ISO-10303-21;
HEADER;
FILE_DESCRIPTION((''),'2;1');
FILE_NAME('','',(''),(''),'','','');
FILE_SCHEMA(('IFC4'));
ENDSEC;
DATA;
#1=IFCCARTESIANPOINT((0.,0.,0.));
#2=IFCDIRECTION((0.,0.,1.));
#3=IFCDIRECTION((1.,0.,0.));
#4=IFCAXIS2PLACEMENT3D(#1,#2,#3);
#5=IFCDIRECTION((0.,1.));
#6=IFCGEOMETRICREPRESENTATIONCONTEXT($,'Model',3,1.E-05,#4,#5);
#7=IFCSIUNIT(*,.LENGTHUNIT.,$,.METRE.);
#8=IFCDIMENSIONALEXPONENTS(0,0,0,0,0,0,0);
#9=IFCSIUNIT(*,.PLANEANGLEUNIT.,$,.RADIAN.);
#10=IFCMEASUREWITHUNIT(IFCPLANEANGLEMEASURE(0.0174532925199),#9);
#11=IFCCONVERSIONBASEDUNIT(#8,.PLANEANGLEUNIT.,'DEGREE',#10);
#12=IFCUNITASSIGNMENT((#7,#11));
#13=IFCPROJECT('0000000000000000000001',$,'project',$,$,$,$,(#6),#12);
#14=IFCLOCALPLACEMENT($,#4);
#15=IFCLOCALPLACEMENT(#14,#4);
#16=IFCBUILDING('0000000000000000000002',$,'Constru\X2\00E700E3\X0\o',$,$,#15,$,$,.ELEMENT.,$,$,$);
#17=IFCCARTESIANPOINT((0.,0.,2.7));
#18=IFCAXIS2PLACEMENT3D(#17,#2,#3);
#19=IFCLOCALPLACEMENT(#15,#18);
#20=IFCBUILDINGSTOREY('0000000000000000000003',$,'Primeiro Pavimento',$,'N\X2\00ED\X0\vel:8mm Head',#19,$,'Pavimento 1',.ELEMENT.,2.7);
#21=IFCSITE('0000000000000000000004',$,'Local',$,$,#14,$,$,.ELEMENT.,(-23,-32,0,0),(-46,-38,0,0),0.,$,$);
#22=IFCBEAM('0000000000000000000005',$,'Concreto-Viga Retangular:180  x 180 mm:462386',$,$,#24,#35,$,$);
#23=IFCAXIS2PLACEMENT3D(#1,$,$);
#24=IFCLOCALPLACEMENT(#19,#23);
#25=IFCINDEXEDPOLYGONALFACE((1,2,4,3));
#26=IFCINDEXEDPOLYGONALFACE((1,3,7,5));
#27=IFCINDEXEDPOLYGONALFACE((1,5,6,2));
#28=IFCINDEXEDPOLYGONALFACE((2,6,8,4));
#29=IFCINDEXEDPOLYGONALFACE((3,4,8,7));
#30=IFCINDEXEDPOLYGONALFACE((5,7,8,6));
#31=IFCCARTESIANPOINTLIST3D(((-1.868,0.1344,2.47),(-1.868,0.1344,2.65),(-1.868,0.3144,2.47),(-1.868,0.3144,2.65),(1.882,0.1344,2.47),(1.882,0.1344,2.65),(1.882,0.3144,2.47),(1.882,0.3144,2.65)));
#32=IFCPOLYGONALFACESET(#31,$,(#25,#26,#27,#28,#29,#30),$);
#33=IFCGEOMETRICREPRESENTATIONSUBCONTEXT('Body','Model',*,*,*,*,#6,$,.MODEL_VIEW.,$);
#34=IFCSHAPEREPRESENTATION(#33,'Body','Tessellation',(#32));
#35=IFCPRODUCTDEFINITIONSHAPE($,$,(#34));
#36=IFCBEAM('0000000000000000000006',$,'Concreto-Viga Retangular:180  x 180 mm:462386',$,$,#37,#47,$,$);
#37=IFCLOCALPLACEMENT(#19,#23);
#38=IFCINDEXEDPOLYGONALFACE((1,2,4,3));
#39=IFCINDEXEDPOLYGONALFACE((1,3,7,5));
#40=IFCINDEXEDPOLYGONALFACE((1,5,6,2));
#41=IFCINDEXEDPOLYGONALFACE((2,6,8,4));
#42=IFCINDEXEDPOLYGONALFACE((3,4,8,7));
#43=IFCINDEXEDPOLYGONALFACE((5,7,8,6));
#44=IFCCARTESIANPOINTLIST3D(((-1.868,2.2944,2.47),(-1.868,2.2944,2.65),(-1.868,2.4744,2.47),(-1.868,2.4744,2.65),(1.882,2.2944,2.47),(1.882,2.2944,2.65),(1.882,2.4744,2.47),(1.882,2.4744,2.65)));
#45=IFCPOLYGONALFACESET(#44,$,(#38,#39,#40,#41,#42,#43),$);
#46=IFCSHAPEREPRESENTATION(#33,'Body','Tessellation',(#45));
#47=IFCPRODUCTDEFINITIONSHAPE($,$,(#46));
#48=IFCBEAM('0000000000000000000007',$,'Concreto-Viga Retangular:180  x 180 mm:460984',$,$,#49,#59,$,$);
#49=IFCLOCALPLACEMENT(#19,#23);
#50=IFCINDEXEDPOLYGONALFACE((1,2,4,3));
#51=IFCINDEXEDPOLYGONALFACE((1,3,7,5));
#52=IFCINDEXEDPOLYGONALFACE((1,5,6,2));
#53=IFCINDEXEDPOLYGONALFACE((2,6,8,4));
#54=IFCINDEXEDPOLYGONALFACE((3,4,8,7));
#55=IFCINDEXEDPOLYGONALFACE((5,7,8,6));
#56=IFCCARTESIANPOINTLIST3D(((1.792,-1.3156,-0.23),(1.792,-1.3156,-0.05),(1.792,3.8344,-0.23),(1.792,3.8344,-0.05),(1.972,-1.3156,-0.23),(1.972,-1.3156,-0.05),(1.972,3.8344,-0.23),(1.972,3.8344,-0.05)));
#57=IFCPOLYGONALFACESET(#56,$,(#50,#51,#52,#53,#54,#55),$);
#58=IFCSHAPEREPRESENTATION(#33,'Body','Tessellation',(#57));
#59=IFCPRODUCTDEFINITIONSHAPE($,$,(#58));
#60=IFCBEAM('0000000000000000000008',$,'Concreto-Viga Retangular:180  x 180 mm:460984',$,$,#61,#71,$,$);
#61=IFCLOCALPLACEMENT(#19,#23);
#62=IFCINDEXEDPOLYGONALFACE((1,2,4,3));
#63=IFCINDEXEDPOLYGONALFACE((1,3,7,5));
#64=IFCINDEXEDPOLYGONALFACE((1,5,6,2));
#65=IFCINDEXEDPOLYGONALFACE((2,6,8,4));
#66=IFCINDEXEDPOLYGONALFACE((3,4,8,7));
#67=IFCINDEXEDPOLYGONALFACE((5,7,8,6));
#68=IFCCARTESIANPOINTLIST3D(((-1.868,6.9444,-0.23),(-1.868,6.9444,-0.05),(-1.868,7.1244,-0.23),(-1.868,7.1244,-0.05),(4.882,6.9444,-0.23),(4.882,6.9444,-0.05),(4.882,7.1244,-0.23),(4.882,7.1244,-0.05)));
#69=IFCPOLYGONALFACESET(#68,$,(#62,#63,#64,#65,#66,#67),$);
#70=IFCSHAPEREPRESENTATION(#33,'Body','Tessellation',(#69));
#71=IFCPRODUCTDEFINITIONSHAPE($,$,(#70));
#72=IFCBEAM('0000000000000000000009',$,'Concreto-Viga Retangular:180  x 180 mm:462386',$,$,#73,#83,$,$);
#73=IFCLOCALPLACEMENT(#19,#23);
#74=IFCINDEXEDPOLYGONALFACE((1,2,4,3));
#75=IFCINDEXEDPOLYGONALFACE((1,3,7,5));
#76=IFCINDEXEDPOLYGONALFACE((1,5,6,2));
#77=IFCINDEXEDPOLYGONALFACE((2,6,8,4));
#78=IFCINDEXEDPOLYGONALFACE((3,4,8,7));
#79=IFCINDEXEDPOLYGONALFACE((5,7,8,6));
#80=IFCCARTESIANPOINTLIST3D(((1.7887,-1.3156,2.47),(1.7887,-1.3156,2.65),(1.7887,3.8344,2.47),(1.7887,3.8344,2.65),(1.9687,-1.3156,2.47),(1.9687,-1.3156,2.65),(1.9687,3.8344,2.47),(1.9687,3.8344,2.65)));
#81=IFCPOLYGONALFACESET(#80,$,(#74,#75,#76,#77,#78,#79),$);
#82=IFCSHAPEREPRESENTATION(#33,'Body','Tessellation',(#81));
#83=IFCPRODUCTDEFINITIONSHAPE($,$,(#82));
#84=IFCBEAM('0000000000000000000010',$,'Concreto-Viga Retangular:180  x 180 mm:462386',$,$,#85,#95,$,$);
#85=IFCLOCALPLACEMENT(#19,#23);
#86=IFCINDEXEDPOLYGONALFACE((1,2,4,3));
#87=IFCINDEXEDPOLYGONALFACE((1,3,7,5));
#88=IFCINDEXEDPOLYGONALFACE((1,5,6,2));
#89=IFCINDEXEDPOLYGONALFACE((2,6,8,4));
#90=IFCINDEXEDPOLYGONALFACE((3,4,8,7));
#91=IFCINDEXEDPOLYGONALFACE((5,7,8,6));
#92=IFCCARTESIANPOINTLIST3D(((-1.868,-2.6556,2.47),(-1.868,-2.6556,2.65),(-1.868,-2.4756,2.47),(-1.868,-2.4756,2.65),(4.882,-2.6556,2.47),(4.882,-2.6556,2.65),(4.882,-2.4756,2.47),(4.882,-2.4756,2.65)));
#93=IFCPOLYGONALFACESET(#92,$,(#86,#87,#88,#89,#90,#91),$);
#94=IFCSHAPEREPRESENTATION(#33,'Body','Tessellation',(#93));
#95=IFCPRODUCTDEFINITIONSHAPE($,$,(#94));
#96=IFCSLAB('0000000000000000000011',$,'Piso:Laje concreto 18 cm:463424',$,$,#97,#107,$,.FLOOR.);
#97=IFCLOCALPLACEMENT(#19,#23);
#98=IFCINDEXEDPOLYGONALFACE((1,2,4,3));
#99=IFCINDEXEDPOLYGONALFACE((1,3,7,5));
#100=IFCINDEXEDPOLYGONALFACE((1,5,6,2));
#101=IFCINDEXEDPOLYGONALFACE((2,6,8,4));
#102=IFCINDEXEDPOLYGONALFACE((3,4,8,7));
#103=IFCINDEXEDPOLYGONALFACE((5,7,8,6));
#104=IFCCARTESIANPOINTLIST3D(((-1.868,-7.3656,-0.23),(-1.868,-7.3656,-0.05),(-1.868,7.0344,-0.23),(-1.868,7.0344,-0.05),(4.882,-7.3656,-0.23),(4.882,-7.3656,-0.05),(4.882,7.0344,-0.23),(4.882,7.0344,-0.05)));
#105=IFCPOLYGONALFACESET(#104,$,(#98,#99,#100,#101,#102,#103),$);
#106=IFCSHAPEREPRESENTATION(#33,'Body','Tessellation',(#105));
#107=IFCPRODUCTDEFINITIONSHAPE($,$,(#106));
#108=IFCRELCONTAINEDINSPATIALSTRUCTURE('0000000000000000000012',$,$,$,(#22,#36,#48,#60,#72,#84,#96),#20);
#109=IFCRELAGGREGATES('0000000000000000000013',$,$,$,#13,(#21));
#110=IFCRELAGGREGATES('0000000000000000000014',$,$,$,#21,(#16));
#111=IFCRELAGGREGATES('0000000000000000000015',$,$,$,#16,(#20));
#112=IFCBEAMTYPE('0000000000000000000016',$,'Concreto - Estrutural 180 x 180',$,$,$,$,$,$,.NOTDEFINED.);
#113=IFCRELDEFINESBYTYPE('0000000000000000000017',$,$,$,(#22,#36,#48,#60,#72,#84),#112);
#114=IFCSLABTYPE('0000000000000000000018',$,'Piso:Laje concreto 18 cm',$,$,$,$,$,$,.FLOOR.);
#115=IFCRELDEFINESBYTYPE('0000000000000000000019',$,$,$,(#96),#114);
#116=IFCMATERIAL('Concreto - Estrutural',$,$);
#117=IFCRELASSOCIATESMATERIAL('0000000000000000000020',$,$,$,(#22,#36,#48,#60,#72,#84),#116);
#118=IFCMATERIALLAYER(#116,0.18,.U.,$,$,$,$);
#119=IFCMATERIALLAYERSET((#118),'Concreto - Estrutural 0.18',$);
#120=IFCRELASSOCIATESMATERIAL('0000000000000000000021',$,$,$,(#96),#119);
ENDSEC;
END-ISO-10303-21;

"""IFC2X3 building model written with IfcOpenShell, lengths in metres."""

from ifc_helpers import new_model, entity, si_unit, converted_unit, direction, frame, frame_2d, origin_with_axes, place, context, subcontext, project, spatial, polyline, rectangle, outline, extrude, material, layer, layer_set, layer_usage, type_object, element, save


model = new_model("IFC2X3")

# Units and contexts
model_context = context("Model", 3, precision=1e-05, world=origin_with_axes(), true_north=direction((0.0, 1.0)))
body_context = subcontext(model_context, "Body", "Model", "MODEL_VIEW")
ifc_project = project(units=[si_unit("LENGTHUNIT", "METRE"), converted_unit("PLANEANGLEUNIT", "DEGREE", entity("IfcPlaneAngleMeasure", 0.0174532925199), si_unit("PLANEANGLEUNIT", "RADIAN"), dimensions=[0, 0, 0, 0, 0, 0, 0])], contexts=[model_context])

# Site, building, storey
site_placement = place(None, origin_with_axes())
site = spatial("IfcSite", under=ifc_project, at=site_placement, Name="Local", CompositionType="ELEMENT", RefLatitude=(-23, -32, 0, 0), RefLongitude=(-46, -38, 0, 0), RefElevation=0.0)
building_placement = place(site_placement, origin_with_axes())
building = spatial("IfcBuilding", under=site, at=building_placement, Name="Construção", CompositionType="ELEMENT")
storey_placement = place(building_placement, frame((0.0, 0.0, 2.7), z_axis=(0.0, 0.0, 1.0), x_axis=(1.0, 0.0, 0.0)))
storey = spatial("IfcBuildingStorey", under=building, at=storey_placement, Name="Primeiro Pavimento", ObjectType="Nível:8mm Head", LongName="Pavimento 1", CompositionType="ELEMENT", Elevation=2.7)

# Shared definitions
ifc_material = material(Name="Concreto - Estrutural")

# Beams
beam_type_1 = type_object("IfcBeamType", Name="Concreto - Estrutural 180 x 180", PredefinedType="NOTDEFINED")
for number, where, z_axis, x_axis, name in (
    (1, (1.882, 0.2244, 2.65), (0.0, 0.0, 1.0), (0.0, 1.0, 0.0), "Concreto-Viga Retangular:180  x 180 mm:462386"),
    (2, (1.882, 2.3844, 2.65), (0.0, 0.0, 1.0), (0.0, 1.0, 0.0), "Concreto-Viga Retangular:180  x 180 mm:462386"),
):
    element("IfcBeam", number, at=place(storey_placement, frame(where, z_axis=z_axis, x_axis=x_axis)), inside=storey, type_object=beam_type_1, material=ifc_material, Name=name, context=body_context, shape_type="SweptSolid", body=[
        extrude(rectangle(XDim=0.18, YDim=0.18, at=frame_2d((-0.09, 0.0), x_axis=(1.0, 0.0))), frame((0.0, 0.0, 0.0), z_axis=(0.0, 1.0, 0.0), x_axis=(0.0, 0.0, 1.0)), (0.0, 0.0, 1.0), 3.75),
    ])
beam_1_placement = place(storey_placement, frame((1.882, -1.3156, -0.05), z_axis=(0.0, 0.0, 1.0), x_axis=(1.0, 0.0, 0.0)))
element("IfcBeam", 3, at=beam_1_placement, inside=storey, type_object=beam_type_1, material=ifc_material, Name="Concreto-Viga Retangular:180  x 180 mm:460984", context=body_context, shape_type="SweptSolid", body=[
    extrude(rectangle(XDim=0.18, YDim=0.18, at=frame_2d((-0.09, 0.0), x_axis=(1.0, 0.0))), frame((0.0, 0.0, 0.0), z_axis=(0.0, 1.0, 0.0), x_axis=(0.0, 0.0, 1.0)), (0.0, 0.0, 1.0), 5.15),
])
beam_2_placement = place(storey_placement, frame((4.882, 7.0344, -0.05), z_axis=(0.0, 0.0, 1.0), x_axis=(0.0, 1.0, 0.0)))
element("IfcBeam", 4, at=beam_2_placement, inside=storey, type_object=beam_type_1, material=ifc_material, Name="Concreto-Viga Retangular:180  x 180 mm:460984", context=body_context, shape_type="SweptSolid", body=[
    extrude(rectangle(XDim=0.18, YDim=0.18, at=frame_2d((-0.09, 0.0), x_axis=(1.0, 0.0))), frame((0.0, 0.0, 0.0), z_axis=(0.0, 1.0, 0.0), x_axis=(0.0, 0.0, 1.0)), (0.0, 0.0, 1.0), 6.75),
])
beam_3_placement = place(storey_placement, frame((1.8787, 3.8344, 2.65), z_axis=(0.0, 0.0, 1.0), x_axis=(-1.0, 0.0, 0.0)))
element("IfcBeam", 5, at=beam_3_placement, inside=storey, type_object=beam_type_1, material=ifc_material, Name="Concreto-Viga Retangular:180  x 180 mm:462386", context=body_context, shape_type="SweptSolid", body=[
    extrude(rectangle(XDim=0.18, YDim=0.18, at=frame_2d((-0.09, 0.0), x_axis=(1.0, 0.0))), frame((0.0, 0.0, 0.0), z_axis=(0.0, 1.0, 0.0), x_axis=(0.0, 0.0, 1.0)), (0.0, 0.0, 1.0), 5.15),
])
beam_4_placement = place(storey_placement, frame((4.882, -2.5656, 2.65), z_axis=(0.0, 0.0, 1.0), x_axis=(0.0, 1.0, 0.0)))
element("IfcBeam", 6, at=beam_4_placement, inside=storey, type_object=beam_type_1, material=ifc_material, Name="Concreto-Viga Retangular:180  x 180 mm:462386", context=body_context, shape_type="SweptSolid", body=[
    extrude(rectangle(XDim=0.18, YDim=0.18, at=frame_2d((-0.09, 0.0), x_axis=(1.0, 0.0))), frame((0.0, 0.0, 0.0), z_axis=(0.0, 1.0, 0.0), x_axis=(0.0, 0.0, 1.0)), (0.0, 0.0, 1.0), 6.75),
])

# Slab
ifc_layer = layer(ifc_material, 0.18, ventilated="UNKNOWN")
ifc_layer_set = layer_set([ifc_layer], Name="Concreto - Estrutural 0.18")
ifc_layer_usage = layer_usage(ifc_layer_set, "AXIS3", "NEGATIVE", 0.18)
slab_type = type_object("IfcSlabType", Name="Piso:Laje concreto 18 cm", PredefinedType="FLOOR")
slab_placement = place(storey_placement, frame((-1.868, 7.0344, -0.05), z_axis=(0.0, 0.0, 1.0), x_axis=(1.0, 0.0, 0.0)))
element("IfcSlab", 7, at=slab_placement, inside=storey, type_object=slab_type, material=ifc_layer_usage, Name="Piso:Laje concreto 18 cm:463424", PredefinedType="FLOOR", context=body_context, shape_type="SweptSolid", body=[
    extrude(outline(polyline([(0.0, 0.0), (0.0, -14.4), (6.75, -14.4), (6.75, 0.0), (0.0, 0.0)])), frame((0.0, 0.0, -0.18), z_axis=(0.0, 0.0, 1.0), x_axis=(1.0, 0.0, 0.0)), (0.0, 0.0, 1.0), 0.18),
])

save(model, "model.ifc")
